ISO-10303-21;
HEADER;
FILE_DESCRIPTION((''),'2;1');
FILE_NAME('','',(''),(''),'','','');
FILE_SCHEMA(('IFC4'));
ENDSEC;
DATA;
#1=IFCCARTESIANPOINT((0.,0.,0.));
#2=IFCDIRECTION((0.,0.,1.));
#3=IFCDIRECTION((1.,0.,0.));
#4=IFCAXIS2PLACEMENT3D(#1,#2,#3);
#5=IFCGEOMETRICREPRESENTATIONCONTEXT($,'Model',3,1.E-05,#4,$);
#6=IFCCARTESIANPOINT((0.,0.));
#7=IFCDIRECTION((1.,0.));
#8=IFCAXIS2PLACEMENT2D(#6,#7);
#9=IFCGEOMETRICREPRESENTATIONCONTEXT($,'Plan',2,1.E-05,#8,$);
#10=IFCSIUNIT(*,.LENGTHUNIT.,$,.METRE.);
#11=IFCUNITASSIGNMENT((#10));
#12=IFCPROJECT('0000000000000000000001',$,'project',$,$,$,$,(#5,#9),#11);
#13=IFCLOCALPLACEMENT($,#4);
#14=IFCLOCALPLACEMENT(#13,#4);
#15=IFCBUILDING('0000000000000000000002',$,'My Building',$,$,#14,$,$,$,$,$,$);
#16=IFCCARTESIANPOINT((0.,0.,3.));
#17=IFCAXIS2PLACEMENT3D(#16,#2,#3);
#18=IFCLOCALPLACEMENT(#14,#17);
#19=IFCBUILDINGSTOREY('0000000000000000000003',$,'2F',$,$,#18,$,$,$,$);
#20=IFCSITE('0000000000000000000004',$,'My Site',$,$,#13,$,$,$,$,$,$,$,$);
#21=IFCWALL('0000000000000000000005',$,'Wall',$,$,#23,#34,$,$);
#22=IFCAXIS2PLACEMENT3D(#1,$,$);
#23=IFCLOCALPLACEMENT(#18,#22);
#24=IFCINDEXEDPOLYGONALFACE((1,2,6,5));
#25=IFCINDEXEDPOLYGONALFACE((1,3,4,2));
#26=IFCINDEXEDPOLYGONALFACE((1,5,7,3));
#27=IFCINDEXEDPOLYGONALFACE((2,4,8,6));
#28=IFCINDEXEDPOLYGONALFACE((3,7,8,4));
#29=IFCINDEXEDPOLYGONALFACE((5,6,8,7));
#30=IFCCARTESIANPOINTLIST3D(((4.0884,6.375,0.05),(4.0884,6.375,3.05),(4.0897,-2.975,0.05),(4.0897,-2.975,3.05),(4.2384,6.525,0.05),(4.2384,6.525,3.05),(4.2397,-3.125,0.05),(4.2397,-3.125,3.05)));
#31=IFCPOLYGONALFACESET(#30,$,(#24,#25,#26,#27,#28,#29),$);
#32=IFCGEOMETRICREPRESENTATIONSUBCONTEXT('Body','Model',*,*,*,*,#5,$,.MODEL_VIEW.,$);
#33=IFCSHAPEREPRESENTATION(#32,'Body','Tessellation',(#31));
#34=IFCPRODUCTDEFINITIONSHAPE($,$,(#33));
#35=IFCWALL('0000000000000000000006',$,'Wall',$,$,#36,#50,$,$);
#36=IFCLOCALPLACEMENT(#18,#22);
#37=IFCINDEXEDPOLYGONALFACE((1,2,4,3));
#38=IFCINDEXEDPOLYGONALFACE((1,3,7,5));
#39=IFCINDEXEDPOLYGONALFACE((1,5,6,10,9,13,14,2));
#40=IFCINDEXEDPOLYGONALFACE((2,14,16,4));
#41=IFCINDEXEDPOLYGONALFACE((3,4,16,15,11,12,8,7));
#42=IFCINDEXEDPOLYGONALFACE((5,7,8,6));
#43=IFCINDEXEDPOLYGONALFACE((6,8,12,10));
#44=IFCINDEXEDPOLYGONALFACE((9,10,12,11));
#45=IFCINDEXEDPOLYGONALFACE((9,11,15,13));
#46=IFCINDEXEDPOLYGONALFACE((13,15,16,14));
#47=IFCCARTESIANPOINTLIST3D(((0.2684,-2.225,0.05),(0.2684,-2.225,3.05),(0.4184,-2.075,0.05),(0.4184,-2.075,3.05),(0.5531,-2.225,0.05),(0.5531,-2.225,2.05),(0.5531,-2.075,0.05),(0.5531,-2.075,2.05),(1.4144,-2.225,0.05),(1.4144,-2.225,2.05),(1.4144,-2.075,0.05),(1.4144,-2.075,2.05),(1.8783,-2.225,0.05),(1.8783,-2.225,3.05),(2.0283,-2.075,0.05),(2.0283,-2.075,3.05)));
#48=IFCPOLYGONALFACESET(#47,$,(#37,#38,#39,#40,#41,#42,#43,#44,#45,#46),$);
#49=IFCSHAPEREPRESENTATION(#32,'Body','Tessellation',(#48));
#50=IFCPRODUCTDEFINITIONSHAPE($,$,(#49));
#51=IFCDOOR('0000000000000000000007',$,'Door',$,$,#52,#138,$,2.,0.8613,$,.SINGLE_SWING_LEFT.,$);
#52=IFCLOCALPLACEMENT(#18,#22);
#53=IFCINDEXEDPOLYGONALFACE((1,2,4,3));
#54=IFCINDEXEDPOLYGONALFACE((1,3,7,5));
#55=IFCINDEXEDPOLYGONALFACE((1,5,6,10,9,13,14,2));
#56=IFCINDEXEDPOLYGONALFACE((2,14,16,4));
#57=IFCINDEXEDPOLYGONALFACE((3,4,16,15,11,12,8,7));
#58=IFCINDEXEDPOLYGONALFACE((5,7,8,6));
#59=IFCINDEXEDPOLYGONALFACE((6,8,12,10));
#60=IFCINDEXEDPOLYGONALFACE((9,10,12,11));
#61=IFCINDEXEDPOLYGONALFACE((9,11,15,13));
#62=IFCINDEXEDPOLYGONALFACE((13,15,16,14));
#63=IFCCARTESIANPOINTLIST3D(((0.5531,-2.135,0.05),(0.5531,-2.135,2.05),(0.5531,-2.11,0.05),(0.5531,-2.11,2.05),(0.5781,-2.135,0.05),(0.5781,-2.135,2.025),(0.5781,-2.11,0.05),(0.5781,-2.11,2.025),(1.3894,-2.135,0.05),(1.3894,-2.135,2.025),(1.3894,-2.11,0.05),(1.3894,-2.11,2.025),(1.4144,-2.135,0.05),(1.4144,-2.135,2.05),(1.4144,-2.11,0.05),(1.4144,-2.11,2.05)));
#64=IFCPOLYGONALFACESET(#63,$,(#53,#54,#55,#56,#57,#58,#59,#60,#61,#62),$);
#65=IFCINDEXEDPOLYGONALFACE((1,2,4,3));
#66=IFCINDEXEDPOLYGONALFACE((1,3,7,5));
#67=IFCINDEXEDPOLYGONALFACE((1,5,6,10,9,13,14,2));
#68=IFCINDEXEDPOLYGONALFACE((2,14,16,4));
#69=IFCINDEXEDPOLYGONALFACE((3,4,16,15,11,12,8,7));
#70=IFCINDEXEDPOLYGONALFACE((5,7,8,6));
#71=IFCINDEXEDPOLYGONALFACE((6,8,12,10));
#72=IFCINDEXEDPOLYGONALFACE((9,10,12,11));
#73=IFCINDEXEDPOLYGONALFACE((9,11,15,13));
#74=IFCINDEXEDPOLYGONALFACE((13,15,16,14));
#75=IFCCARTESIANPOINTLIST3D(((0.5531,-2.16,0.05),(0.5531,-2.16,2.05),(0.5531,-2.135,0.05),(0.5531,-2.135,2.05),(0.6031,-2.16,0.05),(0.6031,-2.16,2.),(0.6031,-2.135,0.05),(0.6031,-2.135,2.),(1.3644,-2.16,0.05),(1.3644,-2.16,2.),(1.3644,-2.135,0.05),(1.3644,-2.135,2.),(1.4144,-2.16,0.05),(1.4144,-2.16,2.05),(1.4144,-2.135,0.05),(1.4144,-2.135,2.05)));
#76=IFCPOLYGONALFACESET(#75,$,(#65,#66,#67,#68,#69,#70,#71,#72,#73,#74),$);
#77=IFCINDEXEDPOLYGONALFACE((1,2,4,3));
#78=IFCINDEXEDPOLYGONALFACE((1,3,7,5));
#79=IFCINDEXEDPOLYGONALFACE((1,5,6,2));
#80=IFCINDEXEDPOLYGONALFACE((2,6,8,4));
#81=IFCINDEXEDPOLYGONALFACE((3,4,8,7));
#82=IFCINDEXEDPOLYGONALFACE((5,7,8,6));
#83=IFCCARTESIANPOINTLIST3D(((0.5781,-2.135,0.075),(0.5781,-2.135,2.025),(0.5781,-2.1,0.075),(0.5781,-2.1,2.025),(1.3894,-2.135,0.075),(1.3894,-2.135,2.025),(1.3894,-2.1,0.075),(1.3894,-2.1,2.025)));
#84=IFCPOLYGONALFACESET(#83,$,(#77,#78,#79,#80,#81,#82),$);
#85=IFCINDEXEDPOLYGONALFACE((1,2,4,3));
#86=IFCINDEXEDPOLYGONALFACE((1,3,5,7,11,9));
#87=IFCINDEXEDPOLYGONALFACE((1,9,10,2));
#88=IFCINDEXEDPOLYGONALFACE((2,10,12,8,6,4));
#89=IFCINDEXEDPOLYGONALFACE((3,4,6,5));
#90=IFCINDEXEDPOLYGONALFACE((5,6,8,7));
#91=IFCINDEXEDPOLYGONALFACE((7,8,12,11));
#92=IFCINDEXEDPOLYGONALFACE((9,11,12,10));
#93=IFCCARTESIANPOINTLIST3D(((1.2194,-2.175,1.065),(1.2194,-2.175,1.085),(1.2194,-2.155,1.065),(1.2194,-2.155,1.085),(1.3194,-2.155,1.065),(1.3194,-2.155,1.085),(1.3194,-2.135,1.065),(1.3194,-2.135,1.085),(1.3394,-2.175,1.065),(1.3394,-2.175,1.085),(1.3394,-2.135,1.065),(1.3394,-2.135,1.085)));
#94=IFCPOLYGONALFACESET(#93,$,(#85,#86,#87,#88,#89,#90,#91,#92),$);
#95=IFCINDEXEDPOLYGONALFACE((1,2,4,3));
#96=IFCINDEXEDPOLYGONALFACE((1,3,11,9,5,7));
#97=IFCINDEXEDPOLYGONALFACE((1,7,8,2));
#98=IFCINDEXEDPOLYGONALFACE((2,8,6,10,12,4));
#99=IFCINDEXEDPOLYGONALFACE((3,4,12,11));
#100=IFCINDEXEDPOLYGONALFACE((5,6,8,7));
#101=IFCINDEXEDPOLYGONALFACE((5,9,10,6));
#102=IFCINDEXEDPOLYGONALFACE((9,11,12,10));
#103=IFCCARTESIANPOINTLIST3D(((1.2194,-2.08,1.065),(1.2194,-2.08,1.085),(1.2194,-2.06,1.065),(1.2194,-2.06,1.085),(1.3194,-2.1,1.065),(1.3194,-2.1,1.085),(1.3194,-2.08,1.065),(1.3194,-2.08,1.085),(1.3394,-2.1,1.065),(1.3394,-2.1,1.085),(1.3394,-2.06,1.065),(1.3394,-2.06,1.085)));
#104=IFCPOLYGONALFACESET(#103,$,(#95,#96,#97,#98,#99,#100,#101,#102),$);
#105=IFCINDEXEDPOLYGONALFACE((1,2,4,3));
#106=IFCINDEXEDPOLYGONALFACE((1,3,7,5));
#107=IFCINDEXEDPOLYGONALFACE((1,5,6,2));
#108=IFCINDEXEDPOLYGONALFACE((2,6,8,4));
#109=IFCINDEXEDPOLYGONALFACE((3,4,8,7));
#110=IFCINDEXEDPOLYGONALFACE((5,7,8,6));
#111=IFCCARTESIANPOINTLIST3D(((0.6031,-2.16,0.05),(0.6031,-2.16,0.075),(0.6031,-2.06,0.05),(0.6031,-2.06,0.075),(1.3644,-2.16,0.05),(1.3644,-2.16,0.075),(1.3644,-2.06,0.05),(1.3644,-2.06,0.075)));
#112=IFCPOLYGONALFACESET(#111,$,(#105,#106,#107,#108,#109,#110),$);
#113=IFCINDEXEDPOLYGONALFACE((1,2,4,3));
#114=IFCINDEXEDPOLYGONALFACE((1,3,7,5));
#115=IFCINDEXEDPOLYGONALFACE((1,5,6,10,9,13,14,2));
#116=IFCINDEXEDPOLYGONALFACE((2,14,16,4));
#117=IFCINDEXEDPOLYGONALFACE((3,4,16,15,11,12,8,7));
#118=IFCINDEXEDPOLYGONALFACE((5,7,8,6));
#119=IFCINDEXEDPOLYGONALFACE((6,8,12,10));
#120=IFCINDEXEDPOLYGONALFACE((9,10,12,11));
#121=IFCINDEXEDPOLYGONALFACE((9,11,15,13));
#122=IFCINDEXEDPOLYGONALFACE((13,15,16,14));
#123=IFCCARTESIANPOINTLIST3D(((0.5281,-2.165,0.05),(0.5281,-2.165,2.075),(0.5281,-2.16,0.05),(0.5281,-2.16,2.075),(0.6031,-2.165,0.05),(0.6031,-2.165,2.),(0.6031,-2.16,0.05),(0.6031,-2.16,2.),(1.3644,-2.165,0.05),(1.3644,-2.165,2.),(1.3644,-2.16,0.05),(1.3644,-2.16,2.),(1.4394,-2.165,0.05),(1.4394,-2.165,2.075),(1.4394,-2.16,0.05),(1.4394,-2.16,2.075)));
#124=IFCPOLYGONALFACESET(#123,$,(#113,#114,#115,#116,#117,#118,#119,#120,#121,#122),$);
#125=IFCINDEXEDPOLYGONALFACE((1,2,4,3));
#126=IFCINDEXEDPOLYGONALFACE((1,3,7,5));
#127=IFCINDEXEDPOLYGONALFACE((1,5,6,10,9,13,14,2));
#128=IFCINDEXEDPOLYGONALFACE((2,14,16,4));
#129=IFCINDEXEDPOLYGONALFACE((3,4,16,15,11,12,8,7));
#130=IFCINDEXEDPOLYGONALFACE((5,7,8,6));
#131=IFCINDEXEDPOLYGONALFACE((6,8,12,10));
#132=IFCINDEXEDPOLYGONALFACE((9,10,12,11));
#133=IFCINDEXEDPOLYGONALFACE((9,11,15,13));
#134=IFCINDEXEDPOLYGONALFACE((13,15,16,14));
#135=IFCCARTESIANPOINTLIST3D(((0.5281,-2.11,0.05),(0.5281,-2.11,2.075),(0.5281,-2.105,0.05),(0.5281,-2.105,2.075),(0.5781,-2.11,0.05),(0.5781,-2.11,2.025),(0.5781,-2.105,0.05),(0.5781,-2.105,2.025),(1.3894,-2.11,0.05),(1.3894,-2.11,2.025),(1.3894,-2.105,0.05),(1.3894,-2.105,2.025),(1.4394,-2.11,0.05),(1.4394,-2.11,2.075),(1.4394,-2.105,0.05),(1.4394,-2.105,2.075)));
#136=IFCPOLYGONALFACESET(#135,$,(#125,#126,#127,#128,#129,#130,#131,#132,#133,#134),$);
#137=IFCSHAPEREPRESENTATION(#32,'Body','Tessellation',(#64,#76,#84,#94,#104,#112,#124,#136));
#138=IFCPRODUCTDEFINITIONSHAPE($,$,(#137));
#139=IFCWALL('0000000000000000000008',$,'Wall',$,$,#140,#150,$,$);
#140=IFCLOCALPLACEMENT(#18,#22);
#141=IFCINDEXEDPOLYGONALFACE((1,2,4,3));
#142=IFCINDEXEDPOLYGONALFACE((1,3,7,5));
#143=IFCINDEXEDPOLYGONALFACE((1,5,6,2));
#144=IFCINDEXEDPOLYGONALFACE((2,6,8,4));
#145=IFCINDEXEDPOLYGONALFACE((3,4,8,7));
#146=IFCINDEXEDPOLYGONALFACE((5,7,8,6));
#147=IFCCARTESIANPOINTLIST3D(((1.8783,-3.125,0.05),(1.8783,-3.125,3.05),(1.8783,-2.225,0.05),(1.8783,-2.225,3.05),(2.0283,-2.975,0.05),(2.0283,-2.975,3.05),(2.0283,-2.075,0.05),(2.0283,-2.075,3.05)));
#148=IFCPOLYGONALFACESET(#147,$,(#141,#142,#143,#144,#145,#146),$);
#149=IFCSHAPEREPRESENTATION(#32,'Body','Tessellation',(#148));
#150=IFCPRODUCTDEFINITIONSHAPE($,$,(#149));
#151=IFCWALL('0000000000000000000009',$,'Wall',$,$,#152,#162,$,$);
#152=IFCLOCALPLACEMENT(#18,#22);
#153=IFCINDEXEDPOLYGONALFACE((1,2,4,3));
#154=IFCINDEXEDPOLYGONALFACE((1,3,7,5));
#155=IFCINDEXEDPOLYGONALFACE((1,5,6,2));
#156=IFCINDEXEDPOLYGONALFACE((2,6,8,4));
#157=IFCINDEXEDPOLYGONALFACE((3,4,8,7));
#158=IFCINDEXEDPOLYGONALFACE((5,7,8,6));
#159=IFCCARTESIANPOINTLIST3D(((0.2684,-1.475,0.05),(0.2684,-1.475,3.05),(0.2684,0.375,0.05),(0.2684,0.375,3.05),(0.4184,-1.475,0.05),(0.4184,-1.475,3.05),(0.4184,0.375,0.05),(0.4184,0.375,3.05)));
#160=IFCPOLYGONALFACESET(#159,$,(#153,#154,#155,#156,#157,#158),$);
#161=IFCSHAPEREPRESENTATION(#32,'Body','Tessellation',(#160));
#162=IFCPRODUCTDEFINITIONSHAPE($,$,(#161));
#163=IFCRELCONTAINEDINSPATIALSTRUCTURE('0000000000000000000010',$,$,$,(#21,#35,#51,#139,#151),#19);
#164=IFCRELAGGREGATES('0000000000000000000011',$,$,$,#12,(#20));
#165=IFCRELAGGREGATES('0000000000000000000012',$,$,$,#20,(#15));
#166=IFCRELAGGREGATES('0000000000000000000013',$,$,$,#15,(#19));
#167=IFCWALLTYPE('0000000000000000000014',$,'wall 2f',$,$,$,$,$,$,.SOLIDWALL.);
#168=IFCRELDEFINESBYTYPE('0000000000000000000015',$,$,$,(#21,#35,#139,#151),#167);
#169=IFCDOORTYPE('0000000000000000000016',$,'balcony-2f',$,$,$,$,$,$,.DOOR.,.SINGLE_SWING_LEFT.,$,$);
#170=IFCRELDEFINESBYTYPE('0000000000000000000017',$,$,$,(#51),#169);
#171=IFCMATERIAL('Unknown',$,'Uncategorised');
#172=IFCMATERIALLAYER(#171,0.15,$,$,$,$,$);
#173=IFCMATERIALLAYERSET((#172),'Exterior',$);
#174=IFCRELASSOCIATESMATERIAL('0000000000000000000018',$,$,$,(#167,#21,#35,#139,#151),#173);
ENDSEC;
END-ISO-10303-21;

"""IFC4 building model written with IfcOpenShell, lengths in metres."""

from ifc_helpers import new_model, entity, si_unit, frame, origin_with_axes, origin_2d_with_axis, place, context, subcontext, project, spatial, line, indexed_curve, outline, extrude, shape, source, transform, mapped, material, layer, layer_set, layer_usage, type_object, type_shapes, element, fill, save


model = new_model("IFC4")

# Units and contexts
model_context = context("Model", 3, precision=1e-05, world=origin_with_axes())
plan_context = context("Plan", 2, precision=1e-05, world=origin_2d_with_axis())
body_context_1 = subcontext(model_context, "Body", "Model", "MODEL_VIEW")
body_context_2 = subcontext(plan_context, "Body", "Plan", "PLAN_VIEW")
ifc_project = project(units=[si_unit("LENGTHUNIT", "METRE")], contexts=[model_context, plan_context])

# Site, building, storey
site_placement = place(None, origin_with_axes())
site = spatial("IfcSite", under=ifc_project, at=site_placement, Name="My Site")
building_placement = place(site_placement, origin_with_axes())
building = spatial("IfcBuilding", under=site, at=building_placement, Name="My Building")
storey_placement = place(building_placement, frame((0.0, 0.0, 3.0), z_axis=(0.0, 0.0, 1.0), x_axis=(1.0, 0.0, 0.0)))
storey = spatial("IfcBuildingStorey", under=building, at=storey_placement, Name="2F")

# Wall
ifc_material = material(Name="Unknown", Category="Uncategorised")
ifc_layer_1 = layer(ifc_material, 0.15)
ifc_layer_set_1 = layer_set([ifc_layer_1], Name="Exterior")
ifc_layer_usage_1 = layer_usage(ifc_layer_set_1, "AXIS2", "POSITIVE", 0.0)
wall_type_1 = type_object("IfcWallType", Name="wall 2f", PredefinedType="SOLIDWALL", material=ifc_layer_set_1)
wall_1_placement = place(storey_placement, frame((4.2397, -3.125, 0.05), z_axis=(0.0, 0.0, 1.0), x_axis=(-0.000142, 1.0, 0.0)))
element("IfcWall", 1, at=wall_1_placement, inside=storey, type_object=wall_type_1, material=ifc_layer_usage_1, Name="Wall", context=body_context_1, shape_type="SweptSolid", body=[
    extrude(outline(indexed_curve([(0.0, 0.0), (0.15, 0.15), (9.5, 0.15), (9.65, 0.0)], segments=[line(1, 2, 3, 4, 1)])), origin_with_axes(), (0.0, 0.0, 1.0), 3.0),
])

# Wall, opening, door
ifc_layer_usage_2 = layer_usage(ifc_layer_set_1, "AXIS2", "POSITIVE", 0.0)
wall_2_placement = place(storey_placement, frame((0.2684, -2.225, 0.05), z_axis=(0.0, 0.0, 1.0), x_axis=(1.0, 0.0, 0.0)))
wall_2 = element("IfcWall", 2, at=wall_2_placement, inside=storey, type_object=wall_type_1, material=ifc_layer_usage_2, Name="Wall", context=body_context_1, shape_type="SweptSolid", body=[
    extrude(outline(indexed_curve([(0.0, 0.0), (0.15, 0.15), (1.76, 0.15), (1.61, 0.0)], segments=[line(1, 2, 3, 4, 1)])), origin_with_axes(), (0.0, 0.0, 1.0), 3.0),
])
shared_shape_1 = source(origin_with_axes(), body_context_1, "Body", "SweptSolid", [
    extrude(outline(indexed_curve([(0.0, 0.0), (0.8613, 0.0), (0.8613, 2.0), (0.0, 2.0)], segments=[line(1, 2, 3, 4, 1)])), frame((0.0, -0.6, 0.0), z_axis=(0.0, -1.0, 0.0), x_axis=(1.0, 0.0, 0.0)), (0.0, 0.0, -1.0), 1.2),
])
opening_1_placement = place(wall_2_placement, frame((0.2847, 0.065, 0.0), z_axis=(0.0, 0.0, 1.0), x_axis=(1.0, 0.0, 0.0)))
opening_1 = element("IfcOpeningElement", 3, at=opening_1_placement, cuts=wall_2, PredefinedType="OPENING", context=body_context_1, shape_type="MappedRepresentation", body=[
    mapped(shared_shape_1, transform((0.0, 0.0, 0.0), x_axis=(1.0, 0.0, 0.0), y_axis=(0.0, 1.0, 0.0), z_axis=(0.0, 0.0, 1.0), scale=1.0)),
])
door_type_1 = type_object("IfcDoorType", Name="balcony-2f", OperationType="SINGLE_SWING_LEFT", PredefinedType="DOOR")
shared_shape_2 = source(origin_with_axes(), body_context_1, "Body", "SweptSolid", [
    extrude(outline(indexed_curve([(0.0, 0.0), (0.0, 2.0), (0.8613, 2.0), (0.8613, 0.0), (0.8363, 0.0), (0.8363, 1.975), (0.025, 1.975), (0.025, 0.0)], segments=[line(1, 2, 3, 4, 5, 6, 7, 8, 1)])), frame((0.0, 0.025, 0.0), z_axis=(0.0, -1.0, 0.0), x_axis=(1.0, 0.0, 0.0)), (0.0, 0.0, -1.0), 0.025),
    extrude(outline(indexed_curve([(0.0, 0.0), (0.0, 2.0), (0.8613, 2.0), (0.8613, 0.0), (0.8113, 0.0), (0.8113, 1.95), (0.05, 1.95), (0.05, 0.0)], segments=[line(1, 2, 3, 4, 5, 6, 7, 8, 1)])), frame((0.0, 0.0, 0.0), z_axis=(0.0, -1.0, 0.0), x_axis=(1.0, 0.0, 0.0)), (0.0, 0.0, -1.0), 0.025),
    extrude(outline(indexed_curve([(0.0, 0.0), (0.8113, 0.0), (0.8113, 0.035), (0.0, 0.035)], segments=[line(1, 2, 3, 4, 1)])), frame((0.025, 0.025, 0.025), z_axis=(0.0, 0.0, 1.0), x_axis=(1.0, 0.0, 0.0)), (0.0, 0.0, 1.0), 1.95),
    extrude(outline(indexed_curve([(0.0, 0.0), (0.0, -0.04), (-0.12, -0.04), (-0.12, -0.02), (-0.02, -0.02), (-0.02, 0.0)], segments=[line(1, 2, 3, 4, 5, 6, 1)])), frame((0.7863, 0.025, 1.015), z_axis=(0.0, 0.0, 1.0), x_axis=(1.0, 0.0, 0.0)), (0.0, 0.0, 1.0), 0.02),
    extrude(outline(indexed_curve([(0.0, 0.0), (0.0, 0.04), (-0.12, 0.04), (-0.12, 0.02), (-0.02, 0.02), (-0.02, 0.0)], segments=[line(1, 2, 3, 4, 5, 6, 1)])), frame((0.7863, 0.06, 1.015), z_axis=(0.0, 0.0, 1.0), x_axis=(1.0, 0.0, 0.0)), (0.0, 0.0, 1.0), 0.02),
    extrude(outline(indexed_curve([(0.0, 0.0), (0.7613, 0.0), (0.7613, 0.1), (0.0, 0.1)], segments=[line(1, 2, 3, 4, 1)])), frame((0.05, 0.0, 0.0), z_axis=(0.0, 0.0, 1.0), x_axis=(1.0, 0.0, 0.0)), (0.0, 0.0, 1.0), 0.025),
    extrude(outline(indexed_curve([(0.0, 0.0), (0.0, 2.025), (0.9113, 2.025), (0.9113, 0.0), (0.8363, 0.0), (0.8363, 1.95), (0.075, 1.95), (0.075, 0.0)], segments=[line(1, 2, 3, 4, 5, 6, 7, 8, 1)])), frame((-0.025, -0.005, 0.0), z_axis=(0.0, -1.0, 0.0), x_axis=(1.0, 0.0, 0.0)), (0.0, 0.0, -1.0), 0.005),
    extrude(outline(indexed_curve([(0.0, 0.0), (0.0, 2.025), (0.9113, 2.025), (0.9113, 0.0), (0.8613, 0.0), (0.8613, 1.975), (0.05, 1.975), (0.05, 0.0)], segments=[line(1, 2, 3, 4, 5, 6, 7, 8, 1)])), frame((-0.025, 0.05, 0.0), z_axis=(0.0, -1.0, 0.0), x_axis=(1.0, 0.0, 0.0)), (0.0, 0.0, -1.0), 0.005),
])
shared_shape_3 = source(origin_with_axes(), body_context_2, "Body", "Curve2D", [
    entity("IfcIndexedPolyCurve", entity("IfcCartesianPointList2D", [[0.0, 0.0], [0.0, 0.05], [0.025, 0.05], [0.025, 0.025], [0.05, 0.025], [0.05, 0.0]]), [entity("IfcLineIndex", [1, 2, 3, 4, 5, 6, 1])]),
    entity("IfcIndexedPolyCurve", entity("IfcCartesianPointList2D", [[0.8613, 0.0], [0.8613, 0.05], [0.8363, 0.05], [0.8363, 0.025], [0.8113, 0.025], [0.8113, 0.0]]), [entity("IfcLineIndex", [1, 2, 3, 4, 5, 6, 1])]),
    entity("IfcTrimmedCurve", entity("IfcEllipse", entity("IfcAxis2Placement2D", entity("IfcCartesianPoint", [0.06, 0.05]), entity("IfcDirection", [1.0, 0.0])), 0.7763, 0.8113), [entity("IfcCartesianPoint", [0.8363, 0.05])], [entity("IfcCartesianPoint", [0.06, 0.8613])], True, "CARTESIAN"),
    entity("IfcIndexedPolyCurve", entity("IfcCartesianPointList2D", [[0.025, 0.05], [0.06, 0.05], [0.06, 0.8613], [0.025, 0.8613]]), [entity("IfcLineIndex", [1, 2, 3, 4, 1])]),
])
type_shapes(door_type_1, [shared_shape_2, shared_shape_3])
door_1_placement = place(opening_1_placement, frame((0.0, 0.0, 0.0), z_axis=(0.0, 0.0, 1.0), x_axis=(1.0, 0.0, 0.0)))
door_1 = element("IfcDoor", 4, at=door_1_placement, inside=storey, type_object=door_type_1, Name="Door", OperationType="SINGLE_SWING_LEFT", OverallHeight=2.0, OverallWidth=0.8613, shapes=[
    shape(body_context_1, "Body", "MappedRepresentation", [mapped(shared_shape_2, transform((0.0, 0.0, 0.0), x_axis=(1.0, 0.0, 0.0), y_axis=(0.0, 1.0, 0.0), z_axis=(0.0, 0.0, 1.0), scale=1.0))]),
    shape(body_context_2, "Body", "MappedRepresentation", [mapped(shared_shape_3, transform((0.0, 0.0, 0.0), x_axis=(1.0, 0.0, 0.0), y_axis=(0.0, 1.0, 0.0), z_axis=(0.0, 0.0, 1.0), scale=1.0))]),
])
fill(opening_1, door_1)

# Wall
ifc_layer_usage_3 = layer_usage(ifc_layer_set_1, "AXIS2", "POSITIVE", 0.0)
wall_3_placement = place(storey_placement, frame((1.8783, -2.225, 0.05), z_axis=(0.0, 0.0, 1.0), x_axis=(0.0, -1.0, 0.0)))
element("IfcWall", 5, at=wall_3_placement, inside=storey, type_object=wall_type_1, material=ifc_layer_usage_3, Name="Wall", context=body_context_1, shape_type="SweptSolid", body=[
    extrude(outline(indexed_curve([(0.0, 0.0), (-0.15, 0.15), (0.75, 0.15), (0.9, 0.0)], segments=[line(1, 2, 3, 4, 1)])), origin_with_axes(), (0.0, 0.0, 1.0), 3.0),
])

# Wall
ifc_layer_usage_4 = layer_usage(ifc_layer_set_1, "AXIS2", "POSITIVE", 0.0)
wall_4_placement = place(storey_placement, frame((0.2684, 0.375, 0.05), z_axis=(0.0, 0.0, 1.0), x_axis=(0.0, -1.0, 0.0)))
element("IfcWall", 6, at=wall_4_placement, inside=storey, type_object=wall_type_1, material=ifc_layer_usage_4, Name="Wall", context=body_context_1, shape_type="SweptSolid", body=[
    extrude(outline(indexed_curve([(0.0, 0.0), (0.0, 0.15), (1.85, 0.15), (1.85, 0.0)], segments=[line(1, 2, 3, 4, 1)])), origin_with_axes(), (0.0, 0.0, 1.0), 3.0),
])

save(model, "model.ifc")
